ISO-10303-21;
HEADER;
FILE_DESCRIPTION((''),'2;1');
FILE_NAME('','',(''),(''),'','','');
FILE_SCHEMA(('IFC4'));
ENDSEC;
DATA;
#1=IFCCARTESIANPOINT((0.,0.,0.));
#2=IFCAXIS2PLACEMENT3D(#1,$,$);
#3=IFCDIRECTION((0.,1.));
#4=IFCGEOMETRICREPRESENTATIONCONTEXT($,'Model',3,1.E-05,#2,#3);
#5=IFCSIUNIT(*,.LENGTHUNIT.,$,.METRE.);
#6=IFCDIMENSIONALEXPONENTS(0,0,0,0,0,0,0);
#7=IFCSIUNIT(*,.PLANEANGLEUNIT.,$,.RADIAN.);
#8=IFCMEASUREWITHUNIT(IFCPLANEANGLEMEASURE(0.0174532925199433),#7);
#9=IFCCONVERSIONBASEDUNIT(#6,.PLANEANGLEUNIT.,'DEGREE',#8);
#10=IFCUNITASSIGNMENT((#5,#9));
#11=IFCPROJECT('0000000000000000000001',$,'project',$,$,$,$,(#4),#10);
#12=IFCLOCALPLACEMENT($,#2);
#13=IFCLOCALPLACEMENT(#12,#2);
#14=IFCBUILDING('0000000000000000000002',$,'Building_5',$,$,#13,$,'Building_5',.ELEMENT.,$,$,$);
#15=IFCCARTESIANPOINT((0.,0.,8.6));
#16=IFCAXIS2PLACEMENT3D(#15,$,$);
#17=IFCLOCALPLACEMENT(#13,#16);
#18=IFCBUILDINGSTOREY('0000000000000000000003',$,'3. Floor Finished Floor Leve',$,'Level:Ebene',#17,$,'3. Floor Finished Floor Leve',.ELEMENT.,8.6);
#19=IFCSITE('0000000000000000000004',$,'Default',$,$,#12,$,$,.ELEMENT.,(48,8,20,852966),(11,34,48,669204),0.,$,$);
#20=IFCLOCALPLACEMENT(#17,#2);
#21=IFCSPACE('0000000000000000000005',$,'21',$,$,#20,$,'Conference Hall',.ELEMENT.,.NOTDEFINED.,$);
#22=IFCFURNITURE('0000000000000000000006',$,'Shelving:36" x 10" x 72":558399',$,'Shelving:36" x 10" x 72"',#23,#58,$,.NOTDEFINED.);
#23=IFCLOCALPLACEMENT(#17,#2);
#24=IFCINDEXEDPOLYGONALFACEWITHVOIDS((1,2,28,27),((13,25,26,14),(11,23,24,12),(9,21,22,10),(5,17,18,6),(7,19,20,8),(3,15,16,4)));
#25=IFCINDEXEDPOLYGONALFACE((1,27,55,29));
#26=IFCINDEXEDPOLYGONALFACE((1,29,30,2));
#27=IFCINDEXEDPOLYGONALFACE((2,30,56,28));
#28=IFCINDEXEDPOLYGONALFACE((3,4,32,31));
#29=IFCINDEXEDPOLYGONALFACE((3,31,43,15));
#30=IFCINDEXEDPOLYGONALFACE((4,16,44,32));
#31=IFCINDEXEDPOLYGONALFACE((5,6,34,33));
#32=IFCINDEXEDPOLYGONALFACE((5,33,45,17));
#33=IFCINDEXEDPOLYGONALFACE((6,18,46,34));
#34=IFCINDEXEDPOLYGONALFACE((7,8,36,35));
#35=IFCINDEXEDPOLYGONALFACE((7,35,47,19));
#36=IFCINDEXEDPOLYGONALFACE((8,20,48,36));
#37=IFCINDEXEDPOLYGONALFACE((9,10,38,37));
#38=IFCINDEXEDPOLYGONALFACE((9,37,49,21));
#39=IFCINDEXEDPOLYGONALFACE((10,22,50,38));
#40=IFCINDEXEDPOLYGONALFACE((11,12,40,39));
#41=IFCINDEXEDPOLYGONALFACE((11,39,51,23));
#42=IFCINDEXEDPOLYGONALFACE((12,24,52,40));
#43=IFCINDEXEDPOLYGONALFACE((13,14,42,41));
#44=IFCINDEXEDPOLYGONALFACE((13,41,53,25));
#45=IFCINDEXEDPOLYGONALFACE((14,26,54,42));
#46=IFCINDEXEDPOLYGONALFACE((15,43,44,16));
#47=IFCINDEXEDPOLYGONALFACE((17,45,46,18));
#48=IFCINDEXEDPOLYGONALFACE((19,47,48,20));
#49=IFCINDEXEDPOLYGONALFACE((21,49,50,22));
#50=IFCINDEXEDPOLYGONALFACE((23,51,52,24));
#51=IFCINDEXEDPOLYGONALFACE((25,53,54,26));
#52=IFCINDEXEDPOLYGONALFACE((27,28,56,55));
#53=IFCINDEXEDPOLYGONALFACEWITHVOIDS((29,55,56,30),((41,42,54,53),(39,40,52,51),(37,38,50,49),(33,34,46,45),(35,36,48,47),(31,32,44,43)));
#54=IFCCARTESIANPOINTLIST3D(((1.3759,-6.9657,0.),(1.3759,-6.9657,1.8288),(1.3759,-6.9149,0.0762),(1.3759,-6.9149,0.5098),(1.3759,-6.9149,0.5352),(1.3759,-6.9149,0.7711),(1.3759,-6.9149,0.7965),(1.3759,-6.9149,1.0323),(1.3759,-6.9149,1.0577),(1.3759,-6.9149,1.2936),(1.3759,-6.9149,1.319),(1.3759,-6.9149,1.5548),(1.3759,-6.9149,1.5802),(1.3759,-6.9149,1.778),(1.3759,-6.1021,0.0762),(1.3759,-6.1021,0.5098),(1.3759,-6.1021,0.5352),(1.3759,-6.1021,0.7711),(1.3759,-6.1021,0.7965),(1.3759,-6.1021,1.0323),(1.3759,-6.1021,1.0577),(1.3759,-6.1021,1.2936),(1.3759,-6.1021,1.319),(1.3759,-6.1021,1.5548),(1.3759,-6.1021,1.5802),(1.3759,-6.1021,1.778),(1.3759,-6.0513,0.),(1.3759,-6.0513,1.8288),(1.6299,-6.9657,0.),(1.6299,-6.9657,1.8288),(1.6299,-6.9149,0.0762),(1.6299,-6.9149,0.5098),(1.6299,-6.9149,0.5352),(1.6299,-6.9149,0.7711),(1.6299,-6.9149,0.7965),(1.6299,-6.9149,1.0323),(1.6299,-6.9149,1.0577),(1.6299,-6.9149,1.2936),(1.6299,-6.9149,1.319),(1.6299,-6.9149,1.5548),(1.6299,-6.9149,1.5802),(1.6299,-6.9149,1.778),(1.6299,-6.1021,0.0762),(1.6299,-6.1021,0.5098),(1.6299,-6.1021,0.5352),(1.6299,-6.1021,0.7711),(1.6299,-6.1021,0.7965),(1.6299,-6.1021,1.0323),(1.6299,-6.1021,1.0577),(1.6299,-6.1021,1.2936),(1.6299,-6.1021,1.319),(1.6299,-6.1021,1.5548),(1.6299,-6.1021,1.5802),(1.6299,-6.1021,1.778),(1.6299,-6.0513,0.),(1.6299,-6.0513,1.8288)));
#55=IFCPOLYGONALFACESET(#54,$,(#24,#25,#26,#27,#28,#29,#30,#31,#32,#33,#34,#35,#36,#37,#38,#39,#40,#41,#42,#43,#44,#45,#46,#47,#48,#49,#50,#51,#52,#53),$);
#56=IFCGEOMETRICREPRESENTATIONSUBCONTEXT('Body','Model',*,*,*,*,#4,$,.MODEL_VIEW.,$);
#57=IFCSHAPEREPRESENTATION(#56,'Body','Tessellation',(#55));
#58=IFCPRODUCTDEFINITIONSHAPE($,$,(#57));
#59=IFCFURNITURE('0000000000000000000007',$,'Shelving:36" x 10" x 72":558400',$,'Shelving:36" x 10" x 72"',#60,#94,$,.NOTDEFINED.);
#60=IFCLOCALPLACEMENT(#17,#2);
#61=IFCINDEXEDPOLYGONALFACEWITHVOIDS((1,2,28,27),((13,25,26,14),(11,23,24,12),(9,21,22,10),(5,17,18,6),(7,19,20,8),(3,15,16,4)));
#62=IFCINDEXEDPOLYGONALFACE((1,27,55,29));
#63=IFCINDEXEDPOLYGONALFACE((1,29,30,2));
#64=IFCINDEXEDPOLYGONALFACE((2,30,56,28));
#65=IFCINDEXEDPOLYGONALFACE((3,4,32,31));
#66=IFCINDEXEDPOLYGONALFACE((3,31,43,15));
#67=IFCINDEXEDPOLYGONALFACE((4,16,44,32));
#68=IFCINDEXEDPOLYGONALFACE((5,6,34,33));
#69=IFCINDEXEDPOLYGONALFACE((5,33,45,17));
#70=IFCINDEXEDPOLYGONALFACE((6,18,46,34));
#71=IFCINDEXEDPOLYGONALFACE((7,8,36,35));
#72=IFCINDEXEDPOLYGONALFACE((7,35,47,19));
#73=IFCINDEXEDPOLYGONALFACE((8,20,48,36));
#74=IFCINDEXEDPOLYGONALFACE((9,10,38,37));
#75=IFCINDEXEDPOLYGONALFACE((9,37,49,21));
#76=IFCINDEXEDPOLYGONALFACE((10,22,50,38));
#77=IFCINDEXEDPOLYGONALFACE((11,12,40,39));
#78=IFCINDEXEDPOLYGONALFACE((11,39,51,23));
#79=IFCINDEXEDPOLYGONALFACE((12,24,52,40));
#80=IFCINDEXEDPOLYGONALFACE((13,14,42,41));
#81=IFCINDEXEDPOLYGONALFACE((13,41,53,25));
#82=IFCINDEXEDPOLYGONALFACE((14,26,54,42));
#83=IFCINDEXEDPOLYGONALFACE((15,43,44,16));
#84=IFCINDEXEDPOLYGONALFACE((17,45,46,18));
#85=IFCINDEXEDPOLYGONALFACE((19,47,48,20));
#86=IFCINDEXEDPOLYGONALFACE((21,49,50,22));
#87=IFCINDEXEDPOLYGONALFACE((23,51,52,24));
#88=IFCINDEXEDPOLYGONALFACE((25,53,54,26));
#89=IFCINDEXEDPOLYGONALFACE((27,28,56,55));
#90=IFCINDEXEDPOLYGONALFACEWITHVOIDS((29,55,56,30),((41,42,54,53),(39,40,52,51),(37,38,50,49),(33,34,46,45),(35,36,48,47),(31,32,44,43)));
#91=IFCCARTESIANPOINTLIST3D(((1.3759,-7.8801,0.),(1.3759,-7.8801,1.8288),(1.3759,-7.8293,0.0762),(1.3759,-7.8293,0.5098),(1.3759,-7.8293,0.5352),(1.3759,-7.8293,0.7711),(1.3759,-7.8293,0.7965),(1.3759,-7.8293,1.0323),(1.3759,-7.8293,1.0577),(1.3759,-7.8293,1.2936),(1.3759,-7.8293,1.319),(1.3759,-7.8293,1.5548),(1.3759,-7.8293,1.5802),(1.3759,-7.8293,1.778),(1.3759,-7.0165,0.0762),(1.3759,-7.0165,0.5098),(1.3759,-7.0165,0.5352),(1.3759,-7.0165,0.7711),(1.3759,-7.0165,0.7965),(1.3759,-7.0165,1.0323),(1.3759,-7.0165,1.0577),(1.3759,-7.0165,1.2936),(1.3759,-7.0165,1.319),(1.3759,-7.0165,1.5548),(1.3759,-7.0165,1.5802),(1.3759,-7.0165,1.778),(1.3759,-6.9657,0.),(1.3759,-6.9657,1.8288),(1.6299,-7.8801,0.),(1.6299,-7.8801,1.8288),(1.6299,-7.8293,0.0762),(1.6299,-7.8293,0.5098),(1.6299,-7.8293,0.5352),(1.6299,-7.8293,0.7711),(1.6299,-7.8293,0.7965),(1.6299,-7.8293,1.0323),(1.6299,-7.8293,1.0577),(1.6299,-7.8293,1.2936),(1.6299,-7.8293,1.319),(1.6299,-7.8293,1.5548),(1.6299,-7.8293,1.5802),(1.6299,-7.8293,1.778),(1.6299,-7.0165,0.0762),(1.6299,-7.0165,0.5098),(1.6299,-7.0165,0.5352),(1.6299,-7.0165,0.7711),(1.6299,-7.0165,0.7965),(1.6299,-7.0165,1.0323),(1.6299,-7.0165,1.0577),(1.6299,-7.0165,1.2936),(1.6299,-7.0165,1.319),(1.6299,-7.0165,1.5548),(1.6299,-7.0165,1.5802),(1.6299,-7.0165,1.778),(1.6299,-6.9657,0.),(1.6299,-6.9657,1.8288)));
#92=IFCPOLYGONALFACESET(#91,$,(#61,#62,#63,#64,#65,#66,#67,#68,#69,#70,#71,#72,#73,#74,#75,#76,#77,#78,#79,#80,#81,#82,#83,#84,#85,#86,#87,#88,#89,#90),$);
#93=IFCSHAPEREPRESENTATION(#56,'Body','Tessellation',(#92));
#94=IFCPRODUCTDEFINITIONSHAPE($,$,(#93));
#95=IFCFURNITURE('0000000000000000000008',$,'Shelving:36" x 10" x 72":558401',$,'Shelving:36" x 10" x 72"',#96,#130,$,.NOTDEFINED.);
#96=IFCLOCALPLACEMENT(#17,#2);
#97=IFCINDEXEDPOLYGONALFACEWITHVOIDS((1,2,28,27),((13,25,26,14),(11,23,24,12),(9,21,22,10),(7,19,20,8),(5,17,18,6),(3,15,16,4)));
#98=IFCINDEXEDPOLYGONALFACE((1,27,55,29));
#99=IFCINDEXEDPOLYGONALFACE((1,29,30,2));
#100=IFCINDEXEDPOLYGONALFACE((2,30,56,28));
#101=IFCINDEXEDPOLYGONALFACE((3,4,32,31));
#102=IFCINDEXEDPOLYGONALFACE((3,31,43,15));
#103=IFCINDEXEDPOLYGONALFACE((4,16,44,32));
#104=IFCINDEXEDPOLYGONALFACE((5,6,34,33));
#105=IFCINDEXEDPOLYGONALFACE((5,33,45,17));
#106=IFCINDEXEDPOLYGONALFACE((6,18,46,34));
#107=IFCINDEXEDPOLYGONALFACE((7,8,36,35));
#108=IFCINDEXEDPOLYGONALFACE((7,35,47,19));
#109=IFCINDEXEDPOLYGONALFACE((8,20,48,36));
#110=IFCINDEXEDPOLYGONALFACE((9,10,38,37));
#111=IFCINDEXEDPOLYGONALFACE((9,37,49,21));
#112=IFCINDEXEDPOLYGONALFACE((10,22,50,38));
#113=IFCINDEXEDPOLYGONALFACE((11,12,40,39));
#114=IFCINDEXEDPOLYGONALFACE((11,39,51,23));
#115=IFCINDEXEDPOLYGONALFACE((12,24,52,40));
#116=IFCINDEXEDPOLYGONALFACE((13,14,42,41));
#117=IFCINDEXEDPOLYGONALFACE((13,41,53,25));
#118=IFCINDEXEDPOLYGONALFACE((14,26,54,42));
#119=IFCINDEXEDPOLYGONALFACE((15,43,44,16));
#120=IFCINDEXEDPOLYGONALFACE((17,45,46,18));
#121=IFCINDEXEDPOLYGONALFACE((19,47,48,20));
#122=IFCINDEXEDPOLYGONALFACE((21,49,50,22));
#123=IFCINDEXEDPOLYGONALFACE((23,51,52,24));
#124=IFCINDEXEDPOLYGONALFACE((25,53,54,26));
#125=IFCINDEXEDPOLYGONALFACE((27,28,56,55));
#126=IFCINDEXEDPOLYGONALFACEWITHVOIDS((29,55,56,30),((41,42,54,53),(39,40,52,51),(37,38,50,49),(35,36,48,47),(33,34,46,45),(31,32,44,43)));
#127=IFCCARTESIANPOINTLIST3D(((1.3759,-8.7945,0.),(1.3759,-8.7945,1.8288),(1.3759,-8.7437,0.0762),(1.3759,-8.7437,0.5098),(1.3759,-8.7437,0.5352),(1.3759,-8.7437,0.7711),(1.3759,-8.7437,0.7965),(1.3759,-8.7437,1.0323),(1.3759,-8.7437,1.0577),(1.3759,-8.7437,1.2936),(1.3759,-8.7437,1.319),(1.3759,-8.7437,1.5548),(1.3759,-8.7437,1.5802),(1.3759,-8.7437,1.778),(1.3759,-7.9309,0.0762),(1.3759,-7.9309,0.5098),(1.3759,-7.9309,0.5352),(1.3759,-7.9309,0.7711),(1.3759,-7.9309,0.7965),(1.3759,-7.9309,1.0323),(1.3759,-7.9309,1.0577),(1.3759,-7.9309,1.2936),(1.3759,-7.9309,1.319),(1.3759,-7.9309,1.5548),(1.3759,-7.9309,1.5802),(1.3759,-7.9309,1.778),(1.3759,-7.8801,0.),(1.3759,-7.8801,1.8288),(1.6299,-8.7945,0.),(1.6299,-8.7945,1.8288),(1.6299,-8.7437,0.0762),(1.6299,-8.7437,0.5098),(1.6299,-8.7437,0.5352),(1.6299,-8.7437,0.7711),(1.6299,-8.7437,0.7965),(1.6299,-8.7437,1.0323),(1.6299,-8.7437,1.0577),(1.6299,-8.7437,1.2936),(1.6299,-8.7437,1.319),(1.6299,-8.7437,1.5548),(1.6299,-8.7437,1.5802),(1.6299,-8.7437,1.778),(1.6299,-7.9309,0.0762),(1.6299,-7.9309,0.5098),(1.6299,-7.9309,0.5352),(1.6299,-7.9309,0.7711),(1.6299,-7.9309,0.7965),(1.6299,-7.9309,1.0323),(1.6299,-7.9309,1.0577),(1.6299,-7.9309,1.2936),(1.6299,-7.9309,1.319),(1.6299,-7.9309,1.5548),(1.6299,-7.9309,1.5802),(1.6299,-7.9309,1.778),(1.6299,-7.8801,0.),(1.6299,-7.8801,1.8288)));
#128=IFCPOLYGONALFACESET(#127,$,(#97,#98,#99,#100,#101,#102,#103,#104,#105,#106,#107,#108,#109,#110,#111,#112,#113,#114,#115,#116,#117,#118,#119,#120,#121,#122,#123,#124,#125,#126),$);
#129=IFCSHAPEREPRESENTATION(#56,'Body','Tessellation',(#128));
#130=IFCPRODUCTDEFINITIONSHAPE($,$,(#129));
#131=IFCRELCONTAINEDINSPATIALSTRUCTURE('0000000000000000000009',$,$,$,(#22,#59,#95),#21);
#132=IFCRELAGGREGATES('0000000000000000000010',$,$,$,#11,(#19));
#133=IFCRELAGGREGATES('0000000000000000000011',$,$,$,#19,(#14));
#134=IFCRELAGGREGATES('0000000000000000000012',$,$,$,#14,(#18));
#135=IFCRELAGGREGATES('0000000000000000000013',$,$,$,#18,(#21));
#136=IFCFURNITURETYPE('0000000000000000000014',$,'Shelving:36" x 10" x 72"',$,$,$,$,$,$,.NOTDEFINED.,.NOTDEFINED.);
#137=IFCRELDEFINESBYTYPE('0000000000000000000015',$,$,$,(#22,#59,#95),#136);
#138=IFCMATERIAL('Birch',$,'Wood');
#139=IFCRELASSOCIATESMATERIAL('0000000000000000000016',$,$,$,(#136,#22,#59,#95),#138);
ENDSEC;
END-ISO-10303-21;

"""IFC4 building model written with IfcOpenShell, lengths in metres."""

from ifc_helpers import new_model, entity, si_unit, converted_unit, direction, frame, origin, place, context, subcontext, project, spatial, indexed_curve, outline, extrude, source, transform, mapped, material, type_object, type_shapes, element, save


model = new_model("IFC4")

# Units and contexts
model_context = context("Model", 3, precision=1e-05, world=origin(), true_north=direction((0.0, 1.0)))
body_context = subcontext(model_context, "Body", "Model", "MODEL_VIEW")
ifc_project = project(units=[si_unit("LENGTHUNIT", "METRE"), converted_unit("PLANEANGLEUNIT", "DEGREE", entity("IfcPlaneAngleMeasure", 0.0174532925199433), si_unit("PLANEANGLEUNIT", "RADIAN"), dimensions=[0, 0, 0, 0, 0, 0, 0])], contexts=[model_context])

# Site, building, storey
site_placement = place(None, origin())
site = spatial("IfcSite", under=ifc_project, at=site_placement, Name="Default", CompositionType="ELEMENT", RefLatitude=(48, 8, 20, 852966), RefLongitude=(11, 34, 48, 669204), RefElevation=0.0)
building_placement = place(site_placement, origin())
building = spatial("IfcBuilding", under=site, at=building_placement, Name="Building_5", LongName="Building_5", CompositionType="ELEMENT")
storey_placement = place(building_placement, frame((0.0, 0.0, 8.6)))
storey = spatial("IfcBuildingStorey", under=building, at=storey_placement, Name="3. Floor Finished Floor Leve", ObjectType="Level:Ebene", LongName="3. Floor Finished Floor Leve", CompositionType="ELEMENT", Elevation=8.6)

# Shared definitions
space_placement = place(storey_placement, origin())
space = spatial("IfcSpace", under=storey, at=space_placement, Name="21", LongName="Conference Hall", CompositionType="ELEMENT", PredefinedType="NOTDEFINED")

# Furniture
ifc_material_1 = material(Name="Birch", Category="Wood")
furniture_type_1 = type_object("IfcFurnitureType", Name="Shelving:36\" x 10\" x 72\"", AssemblyPlace="NOTDEFINED", PredefinedType="NOTDEFINED", material=ifc_material_1)
shared_shape_1 = source(origin(), body_context, "Body", "SweptSolid", [
    extrude(outline(indexed_curve([(-0.4572, -0.9144), (0.4572, -0.9144), (0.4572, 0.9144), (-0.4572, 0.9144), (-0.4572, -0.9144)], self_intersect=False), holes=[indexed_curve([(-0.4064, 0.8636), (0.4064, 0.8636), (0.4064, 0.6658), (-0.4064, 0.6658), (-0.4064, 0.8636)], self_intersect=False), indexed_curve([(-0.4064, -0.8382), (-0.4064, -0.4046), (0.4064, -0.4046), (0.4064, -0.8382), (-0.4064, -0.8382)], self_intersect=False), indexed_curve([(0.4064, 0.1433), (-0.4064, 0.1433), (-0.4064, 0.3792), (0.4064, 0.3792), (0.4064, 0.1433)], self_intersect=False), indexed_curve([(-0.4064, 0.6404), (0.4064, 0.6404), (0.4064, 0.4046), (-0.4064, 0.4046), (-0.4064, 0.6404)], self_intersect=False), indexed_curve([(-0.4064, 0.1179), (0.4064, 0.1179), (0.4064, -0.1179), (-0.4064, -0.1179), (-0.4064, 0.1179)], self_intersect=False), indexed_curve([(-0.4064, -0.1433), (0.4064, -0.1433), (0.4064, -0.3792), (-0.4064, -0.3792), (-0.4064, -0.1433)], self_intersect=False)]), frame((0.0, -0.4318, 0.9144), z_axis=(0.0, 1.0, 0.0), x_axis=(-1.0, 0.0, 0.0)), (0.0, 0.0, 1.0), 0.254),
])
type_shapes(furniture_type_1, [shared_shape_1])
for number, where, z_axis, x_axis, name in (
    (1, (1.8077, -6.5085, 0.0), (0.0, 0.0, 1.0), (0.0, -1.0, 0.0), "Shelving:36\" x 10\" x 72\":558399"),
    (2, (1.8077, -7.4229, 0.0), (0.0, 0.0, 1.0), (0.0, -1.0, 0.0), "Shelving:36\" x 10\" x 72\":558400"),
    (3, (1.8077, -8.3373, 0.0), (0.0, 0.0, 1.0), (0.0, -1.0, 0.0), "Shelving:36\" x 10\" x 72\":558401"),
):
    element("IfcFurniture", number, at=place(space_placement, frame(where, z_axis=z_axis, x_axis=x_axis)), inside=space, type_object=furniture_type_1, material=ifc_material_1, Name=name, ObjectType="Shelving:36\" x 10\" x 72\"", PredefinedType="NOTDEFINED", context=body_context, shape_type="MappedRepresentation", body=[
        mapped(shared_shape_1, transform((0.0, 0.0, 0.0), scale=1.0)),
    ])

save(model, "model.ifc")
